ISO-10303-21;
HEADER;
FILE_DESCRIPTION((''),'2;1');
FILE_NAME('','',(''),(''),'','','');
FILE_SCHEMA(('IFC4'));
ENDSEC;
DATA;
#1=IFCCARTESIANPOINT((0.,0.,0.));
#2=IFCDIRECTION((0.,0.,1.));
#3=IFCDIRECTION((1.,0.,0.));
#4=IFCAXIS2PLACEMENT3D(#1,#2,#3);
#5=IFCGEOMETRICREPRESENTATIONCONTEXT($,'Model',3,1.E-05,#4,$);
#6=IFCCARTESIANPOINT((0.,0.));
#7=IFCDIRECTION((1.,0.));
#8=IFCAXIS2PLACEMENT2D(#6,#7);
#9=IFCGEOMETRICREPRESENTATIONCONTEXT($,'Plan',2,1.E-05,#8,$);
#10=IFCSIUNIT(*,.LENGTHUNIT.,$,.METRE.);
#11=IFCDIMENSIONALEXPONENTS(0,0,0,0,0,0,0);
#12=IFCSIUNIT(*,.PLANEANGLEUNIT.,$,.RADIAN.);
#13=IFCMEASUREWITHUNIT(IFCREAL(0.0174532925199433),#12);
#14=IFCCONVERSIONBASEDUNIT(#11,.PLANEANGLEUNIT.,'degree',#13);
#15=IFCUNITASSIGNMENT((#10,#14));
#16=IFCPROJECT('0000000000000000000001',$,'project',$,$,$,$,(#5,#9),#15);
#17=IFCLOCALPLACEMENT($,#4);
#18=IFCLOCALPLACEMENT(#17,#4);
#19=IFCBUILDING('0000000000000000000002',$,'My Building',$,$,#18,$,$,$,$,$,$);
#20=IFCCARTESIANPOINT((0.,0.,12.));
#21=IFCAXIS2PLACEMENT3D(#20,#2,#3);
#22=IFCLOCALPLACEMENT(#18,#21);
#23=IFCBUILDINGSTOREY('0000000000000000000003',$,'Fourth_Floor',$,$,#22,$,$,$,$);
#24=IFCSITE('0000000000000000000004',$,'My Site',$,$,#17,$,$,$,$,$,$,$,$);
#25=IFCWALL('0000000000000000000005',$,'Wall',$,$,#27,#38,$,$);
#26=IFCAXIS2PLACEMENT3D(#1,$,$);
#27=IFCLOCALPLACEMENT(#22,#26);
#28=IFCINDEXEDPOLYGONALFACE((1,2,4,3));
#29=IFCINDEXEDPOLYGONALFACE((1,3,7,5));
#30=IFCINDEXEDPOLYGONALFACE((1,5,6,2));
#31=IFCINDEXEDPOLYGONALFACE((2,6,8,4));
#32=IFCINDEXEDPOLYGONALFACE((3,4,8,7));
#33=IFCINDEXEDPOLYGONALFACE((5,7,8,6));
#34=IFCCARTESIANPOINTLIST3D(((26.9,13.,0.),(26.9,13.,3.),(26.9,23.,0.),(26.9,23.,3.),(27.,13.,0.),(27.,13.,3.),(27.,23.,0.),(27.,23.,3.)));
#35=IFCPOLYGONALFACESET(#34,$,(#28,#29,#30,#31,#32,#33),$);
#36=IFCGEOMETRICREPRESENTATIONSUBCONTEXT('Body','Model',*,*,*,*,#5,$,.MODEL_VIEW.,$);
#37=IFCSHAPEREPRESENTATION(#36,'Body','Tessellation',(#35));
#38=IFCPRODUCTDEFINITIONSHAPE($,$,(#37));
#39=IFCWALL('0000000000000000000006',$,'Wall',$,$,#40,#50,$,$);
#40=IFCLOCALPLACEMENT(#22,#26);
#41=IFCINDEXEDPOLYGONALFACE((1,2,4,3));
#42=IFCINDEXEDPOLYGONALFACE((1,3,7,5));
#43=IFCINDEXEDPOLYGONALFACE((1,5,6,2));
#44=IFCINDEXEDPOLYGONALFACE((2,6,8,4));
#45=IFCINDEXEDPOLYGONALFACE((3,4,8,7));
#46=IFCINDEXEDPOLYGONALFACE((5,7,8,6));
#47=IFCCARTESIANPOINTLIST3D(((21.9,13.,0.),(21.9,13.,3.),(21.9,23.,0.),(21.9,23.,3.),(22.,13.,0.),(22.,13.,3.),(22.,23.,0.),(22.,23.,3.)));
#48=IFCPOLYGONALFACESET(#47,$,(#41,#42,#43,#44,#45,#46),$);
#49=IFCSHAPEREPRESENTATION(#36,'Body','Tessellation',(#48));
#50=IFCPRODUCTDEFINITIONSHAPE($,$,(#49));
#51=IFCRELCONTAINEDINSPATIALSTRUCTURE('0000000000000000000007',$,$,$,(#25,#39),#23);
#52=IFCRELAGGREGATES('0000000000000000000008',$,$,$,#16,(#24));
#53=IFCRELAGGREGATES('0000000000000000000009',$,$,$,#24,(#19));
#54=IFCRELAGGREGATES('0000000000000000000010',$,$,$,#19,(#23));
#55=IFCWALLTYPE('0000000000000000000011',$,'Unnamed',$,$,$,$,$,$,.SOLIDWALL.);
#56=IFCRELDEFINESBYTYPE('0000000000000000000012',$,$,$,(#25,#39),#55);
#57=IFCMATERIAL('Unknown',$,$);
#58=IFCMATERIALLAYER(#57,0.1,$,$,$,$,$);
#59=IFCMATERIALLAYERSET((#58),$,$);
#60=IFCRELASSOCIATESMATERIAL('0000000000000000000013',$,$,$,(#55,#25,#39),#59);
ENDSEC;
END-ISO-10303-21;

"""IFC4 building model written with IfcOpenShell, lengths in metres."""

from ifc_helpers import new_model, entity, si_unit, converted_unit, frame, origin_with_axes, origin_2d_with_axis, place, context, subcontext, project, spatial, line, indexed_curve, outline, extrude, material, layer, layer_set, layer_usage, type_object, element, save


model = new_model("IFC4")

# Units and contexts
model_context = context("Model", 3, precision=1e-05, world=origin_with_axes())
plan_context = context("Plan", 2, precision=1e-05, world=origin_2d_with_axis())
body_context_1 = subcontext(model_context, "Body", "Model", "MODEL_VIEW")
ifc_project = project(units=[si_unit("LENGTHUNIT", "METRE"), converted_unit("PLANEANGLEUNIT", "degree", entity("IfcReal", 0.0174532925199433), si_unit("PLANEANGLEUNIT", "RADIAN"), dimensions=[0, 0, 0, 0, 0, 0, 0])], contexts=[model_context, plan_context])

# Site, building, storey
site_placement = place(None, origin_with_axes())
site = spatial("IfcSite", under=ifc_project, at=site_placement, Name="My Site")
building_placement = place(site_placement, origin_with_axes())
building = spatial("IfcBuilding", under=site, at=building_placement, Name="My Building")
storey_placement = place(building_placement, frame((0.0, 0.0, 12.0), z_axis=(0.0, 0.0, 1.0), x_axis=(1.0, 0.0, 0.0)))
storey = spatial("IfcBuildingStorey", under=building, at=storey_placement, Name="Fourth_Floor")

# Wall
ifc_material = material(Name="Unknown")
ifc_layer = layer(ifc_material, 0.1)
ifc_layer_set = layer_set([ifc_layer])
ifc_layer_usage_1 = layer_usage(ifc_layer_set, "AXIS2", "POSITIVE", 0.0)
wall_type = type_object("IfcWallType", Name="Unnamed", PredefinedType="SOLIDWALL", material=ifc_layer_set)
wall_1_placement = place(storey_placement, frame((26.9, 23.0, 0.0), z_axis=(0.0, 0.0, 1.0), x_axis=(0.0, -1.0, 0.0)))
element("IfcWall", 1, at=wall_1_placement, inside=storey, type_object=wall_type, material=ifc_layer_usage_1, Name="Wall", context=body_context_1, shape_type="SweptSolid", body=[
    extrude(outline(indexed_curve([(0.0, 0.0), (0.0, 0.1), (10.0, 0.1), (10.0, 0.0)], segments=[line(1, 2, 3, 4, 1)])), origin_with_axes(), (0.0, 0.0, 1.0), 3.0),
])

# Wall
ifc_layer_usage_2 = layer_usage(ifc_layer_set, "AXIS2", "POSITIVE", 0.0)
wall_2_placement = place(storey_placement, frame((21.9, 23.0, 0.0), z_axis=(0.0, 0.0, 1.0), x_axis=(0.0, -1.0, 0.0)))
element("IfcWall", 2, at=wall_2_placement, inside=storey, type_object=wall_type, material=ifc_layer_usage_2, Name="Wall", context=body_context_1, shape_type="SweptSolid", body=[
    extrude(outline(indexed_curve([(0.0, 0.0), (0.0, 0.1), (10.0, 0.1), (10.0, 0.0)], segments=[line(1, 2, 3, 4, 1)])), origin_with_axes(), (0.0, 0.0, 1.0), 3.0),
])

save(model, "model.ifc")
